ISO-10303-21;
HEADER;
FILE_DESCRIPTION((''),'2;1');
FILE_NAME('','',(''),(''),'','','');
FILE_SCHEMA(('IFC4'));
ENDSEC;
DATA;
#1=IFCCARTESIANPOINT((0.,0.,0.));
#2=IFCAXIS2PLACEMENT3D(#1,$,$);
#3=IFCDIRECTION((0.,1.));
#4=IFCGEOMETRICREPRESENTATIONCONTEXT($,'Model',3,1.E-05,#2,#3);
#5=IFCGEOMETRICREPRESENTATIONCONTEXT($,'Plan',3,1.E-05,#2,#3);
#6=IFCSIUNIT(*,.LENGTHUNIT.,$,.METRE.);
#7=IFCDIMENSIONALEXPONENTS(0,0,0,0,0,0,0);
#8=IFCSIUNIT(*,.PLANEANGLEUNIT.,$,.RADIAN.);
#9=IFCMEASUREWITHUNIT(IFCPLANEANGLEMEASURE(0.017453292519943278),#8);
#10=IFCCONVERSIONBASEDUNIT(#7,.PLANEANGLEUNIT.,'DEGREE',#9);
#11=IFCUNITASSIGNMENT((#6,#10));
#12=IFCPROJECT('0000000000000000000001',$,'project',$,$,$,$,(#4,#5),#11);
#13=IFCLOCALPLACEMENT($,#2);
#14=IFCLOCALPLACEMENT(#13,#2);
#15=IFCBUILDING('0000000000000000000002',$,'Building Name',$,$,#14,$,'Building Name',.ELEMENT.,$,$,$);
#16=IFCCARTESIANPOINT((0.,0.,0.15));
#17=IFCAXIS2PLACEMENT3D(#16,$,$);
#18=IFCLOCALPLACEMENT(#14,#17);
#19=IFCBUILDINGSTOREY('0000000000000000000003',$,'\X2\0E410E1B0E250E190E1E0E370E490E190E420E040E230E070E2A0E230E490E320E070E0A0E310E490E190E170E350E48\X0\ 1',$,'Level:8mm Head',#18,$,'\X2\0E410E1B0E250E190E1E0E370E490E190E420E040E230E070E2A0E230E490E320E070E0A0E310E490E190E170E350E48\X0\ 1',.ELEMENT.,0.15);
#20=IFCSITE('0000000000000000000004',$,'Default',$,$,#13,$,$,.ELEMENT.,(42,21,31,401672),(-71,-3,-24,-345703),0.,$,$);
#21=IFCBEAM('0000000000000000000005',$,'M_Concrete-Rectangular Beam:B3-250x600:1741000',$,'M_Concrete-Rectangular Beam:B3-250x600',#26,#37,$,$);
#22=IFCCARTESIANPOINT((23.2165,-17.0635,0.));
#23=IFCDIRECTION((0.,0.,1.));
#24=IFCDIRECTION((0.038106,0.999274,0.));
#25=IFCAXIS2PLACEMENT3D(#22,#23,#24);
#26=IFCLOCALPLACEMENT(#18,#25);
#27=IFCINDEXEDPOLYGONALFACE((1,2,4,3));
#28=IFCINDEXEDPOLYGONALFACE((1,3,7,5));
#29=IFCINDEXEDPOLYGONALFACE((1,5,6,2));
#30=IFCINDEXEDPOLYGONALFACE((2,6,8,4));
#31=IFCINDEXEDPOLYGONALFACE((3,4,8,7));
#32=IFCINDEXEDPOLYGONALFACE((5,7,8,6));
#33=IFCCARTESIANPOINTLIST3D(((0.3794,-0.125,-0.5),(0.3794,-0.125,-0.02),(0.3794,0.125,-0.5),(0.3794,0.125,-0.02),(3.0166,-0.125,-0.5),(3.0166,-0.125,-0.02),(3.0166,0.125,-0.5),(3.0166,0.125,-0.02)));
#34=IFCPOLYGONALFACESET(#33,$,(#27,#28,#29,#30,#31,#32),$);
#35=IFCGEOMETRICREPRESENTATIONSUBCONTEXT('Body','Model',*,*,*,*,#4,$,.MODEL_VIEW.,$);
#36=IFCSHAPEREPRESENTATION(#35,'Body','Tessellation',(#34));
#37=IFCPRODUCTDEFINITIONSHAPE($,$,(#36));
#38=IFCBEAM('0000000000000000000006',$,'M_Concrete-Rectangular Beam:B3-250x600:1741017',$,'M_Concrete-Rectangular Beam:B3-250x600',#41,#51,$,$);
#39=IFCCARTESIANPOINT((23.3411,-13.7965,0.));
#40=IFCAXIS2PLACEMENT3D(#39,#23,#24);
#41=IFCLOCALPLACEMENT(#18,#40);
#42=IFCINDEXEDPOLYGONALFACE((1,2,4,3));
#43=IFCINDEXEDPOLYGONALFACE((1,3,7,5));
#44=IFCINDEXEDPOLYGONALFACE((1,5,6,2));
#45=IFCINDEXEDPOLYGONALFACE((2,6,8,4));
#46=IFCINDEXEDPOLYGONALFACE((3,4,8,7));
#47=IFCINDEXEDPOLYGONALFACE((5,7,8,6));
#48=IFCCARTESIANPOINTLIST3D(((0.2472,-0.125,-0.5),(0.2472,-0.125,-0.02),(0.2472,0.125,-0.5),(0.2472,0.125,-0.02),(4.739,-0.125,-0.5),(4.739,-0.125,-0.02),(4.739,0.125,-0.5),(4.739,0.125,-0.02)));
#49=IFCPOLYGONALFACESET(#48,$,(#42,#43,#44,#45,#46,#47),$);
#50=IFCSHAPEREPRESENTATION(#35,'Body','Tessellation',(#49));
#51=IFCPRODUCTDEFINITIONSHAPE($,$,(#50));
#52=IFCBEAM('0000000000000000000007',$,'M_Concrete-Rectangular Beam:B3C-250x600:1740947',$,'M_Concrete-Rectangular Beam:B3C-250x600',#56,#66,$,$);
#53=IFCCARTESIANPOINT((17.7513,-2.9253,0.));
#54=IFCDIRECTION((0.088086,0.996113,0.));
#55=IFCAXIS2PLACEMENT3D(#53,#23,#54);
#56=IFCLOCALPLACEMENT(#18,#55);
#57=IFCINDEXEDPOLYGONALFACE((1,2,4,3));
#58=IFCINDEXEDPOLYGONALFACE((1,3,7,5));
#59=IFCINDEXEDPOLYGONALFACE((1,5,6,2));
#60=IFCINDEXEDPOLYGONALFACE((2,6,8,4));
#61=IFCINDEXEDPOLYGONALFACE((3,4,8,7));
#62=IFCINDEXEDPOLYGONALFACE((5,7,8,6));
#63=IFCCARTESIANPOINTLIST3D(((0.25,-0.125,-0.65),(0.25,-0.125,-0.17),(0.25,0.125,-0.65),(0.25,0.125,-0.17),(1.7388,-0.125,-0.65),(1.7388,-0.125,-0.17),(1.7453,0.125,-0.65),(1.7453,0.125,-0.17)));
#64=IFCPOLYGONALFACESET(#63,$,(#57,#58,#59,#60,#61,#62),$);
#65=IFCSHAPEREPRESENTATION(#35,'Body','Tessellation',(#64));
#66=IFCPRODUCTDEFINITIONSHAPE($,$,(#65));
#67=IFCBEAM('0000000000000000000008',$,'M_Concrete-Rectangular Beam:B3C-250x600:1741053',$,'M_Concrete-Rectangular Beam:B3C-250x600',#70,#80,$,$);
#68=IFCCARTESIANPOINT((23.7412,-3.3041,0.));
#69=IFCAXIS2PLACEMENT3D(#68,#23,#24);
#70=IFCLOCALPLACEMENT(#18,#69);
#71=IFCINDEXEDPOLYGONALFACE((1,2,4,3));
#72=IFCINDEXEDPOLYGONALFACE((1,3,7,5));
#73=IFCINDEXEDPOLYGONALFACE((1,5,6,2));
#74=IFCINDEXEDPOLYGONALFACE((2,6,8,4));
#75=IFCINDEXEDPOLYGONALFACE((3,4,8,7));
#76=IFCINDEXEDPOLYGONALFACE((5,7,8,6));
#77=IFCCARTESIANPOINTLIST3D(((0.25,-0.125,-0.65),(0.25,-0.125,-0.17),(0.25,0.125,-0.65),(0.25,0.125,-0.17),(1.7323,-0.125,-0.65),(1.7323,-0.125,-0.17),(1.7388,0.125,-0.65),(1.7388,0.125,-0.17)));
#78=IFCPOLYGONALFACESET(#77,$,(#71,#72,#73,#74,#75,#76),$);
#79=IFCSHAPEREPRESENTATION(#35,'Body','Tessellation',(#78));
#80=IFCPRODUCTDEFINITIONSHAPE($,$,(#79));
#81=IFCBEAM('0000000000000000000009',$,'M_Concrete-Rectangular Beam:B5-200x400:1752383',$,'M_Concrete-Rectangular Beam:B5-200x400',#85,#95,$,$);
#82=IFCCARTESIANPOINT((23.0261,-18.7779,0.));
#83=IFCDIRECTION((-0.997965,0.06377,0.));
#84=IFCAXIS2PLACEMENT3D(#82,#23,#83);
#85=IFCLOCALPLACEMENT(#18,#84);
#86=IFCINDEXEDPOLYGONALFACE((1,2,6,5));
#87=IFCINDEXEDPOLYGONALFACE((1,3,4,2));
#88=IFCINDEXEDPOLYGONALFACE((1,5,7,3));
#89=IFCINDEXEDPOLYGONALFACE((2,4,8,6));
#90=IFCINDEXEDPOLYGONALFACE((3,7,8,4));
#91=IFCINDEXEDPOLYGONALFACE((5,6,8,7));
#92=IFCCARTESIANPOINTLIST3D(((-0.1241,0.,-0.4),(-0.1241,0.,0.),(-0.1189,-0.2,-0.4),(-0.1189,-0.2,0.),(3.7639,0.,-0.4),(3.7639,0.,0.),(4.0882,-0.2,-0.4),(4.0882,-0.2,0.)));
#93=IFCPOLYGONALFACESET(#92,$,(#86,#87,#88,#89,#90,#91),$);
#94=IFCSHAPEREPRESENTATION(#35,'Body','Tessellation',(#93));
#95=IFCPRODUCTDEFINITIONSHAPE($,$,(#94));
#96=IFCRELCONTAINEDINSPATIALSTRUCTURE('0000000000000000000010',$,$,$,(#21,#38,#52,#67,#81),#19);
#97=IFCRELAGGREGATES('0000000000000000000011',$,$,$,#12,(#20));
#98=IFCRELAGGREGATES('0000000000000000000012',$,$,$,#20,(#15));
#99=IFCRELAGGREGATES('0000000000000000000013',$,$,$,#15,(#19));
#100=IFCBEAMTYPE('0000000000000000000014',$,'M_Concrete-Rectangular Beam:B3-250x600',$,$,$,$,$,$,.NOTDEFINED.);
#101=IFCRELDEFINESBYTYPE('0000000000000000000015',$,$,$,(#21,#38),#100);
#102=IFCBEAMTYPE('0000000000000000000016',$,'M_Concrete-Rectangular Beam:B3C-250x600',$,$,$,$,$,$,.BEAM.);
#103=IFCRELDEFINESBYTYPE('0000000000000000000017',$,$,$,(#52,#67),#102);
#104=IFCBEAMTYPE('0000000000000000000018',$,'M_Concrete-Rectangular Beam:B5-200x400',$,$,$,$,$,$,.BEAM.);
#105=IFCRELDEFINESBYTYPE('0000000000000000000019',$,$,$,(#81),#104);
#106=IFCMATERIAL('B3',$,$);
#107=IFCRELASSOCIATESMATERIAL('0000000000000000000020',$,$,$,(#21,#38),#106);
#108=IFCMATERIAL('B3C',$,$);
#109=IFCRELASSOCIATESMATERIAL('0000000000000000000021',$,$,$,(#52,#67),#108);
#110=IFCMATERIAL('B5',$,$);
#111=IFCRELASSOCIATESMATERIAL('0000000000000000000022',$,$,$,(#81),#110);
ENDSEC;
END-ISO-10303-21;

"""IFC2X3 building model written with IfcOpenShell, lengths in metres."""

from ifc_helpers import new_model, entity, si_unit, converted_unit, direction, frame, frame_2d, origin, place, context, subcontext, project, spatial, rectangle, extrude, clip, halfspace, material, type_object, element, save


model = new_model("IFC2X3")

# Units and contexts
model_context = context("Model", 3, precision=1e-05, world=origin(), true_north=direction((0.0, 1.0)))
plan_context = context("Plan", 3, precision=1e-05, world=origin(), true_north=direction((0.0, 1.0)))
body_context = subcontext(model_context, "Body", "Model", "MODEL_VIEW")
ifc_project = project(units=[si_unit("LENGTHUNIT", "METRE"), converted_unit("PLANEANGLEUNIT", "DEGREE", entity("IfcPlaneAngleMeasure", 0.017453292519943278), si_unit("PLANEANGLEUNIT", "RADIAN"), dimensions=[0, 0, 0, 0, 0, 0, 0])], contexts=[model_context, plan_context])

# Site, building, storey
site_placement = place(None, origin())
site = spatial("IfcSite", under=ifc_project, at=site_placement, Name="Default", CompositionType="ELEMENT", RefLatitude=(42, 21, 31, 401672), RefLongitude=(-71, -3, -24, -345703), RefElevation=0.0)
building_placement = place(site_placement, origin())
building = spatial("IfcBuilding", under=site, at=building_placement, Name="Building Name", LongName="Building Name", CompositionType="ELEMENT")
storey_placement = place(building_placement, frame((0.0, 0.0, 0.15)))
storey = spatial("IfcBuildingStorey", under=building, at=storey_placement, Name="แปลนพื้นโครงสร้างชั้นที่ 1", ObjectType="Level:8mm Head", LongName="แปลนพื้นโครงสร้างชั้นที่ 1", CompositionType="ELEMENT", Elevation=0.15)

# Beams
ifc_material_1 = material(Name="B3")
beam_type_1 = type_object("IfcBeamType", Name="M_Concrete-Rectangular Beam:B3-250x600", PredefinedType="NOTDEFINED")
beam_1_placement = place(storey_placement, frame((23.2165, -17.0635, 0.0), z_axis=(0.0, 0.0, 1.0), x_axis=(0.038106, 0.999274, 0.0)))
element("IfcBeam", 1, at=beam_1_placement, inside=storey, type_object=beam_type_1, material=ifc_material_1, Name="M_Concrete-Rectangular Beam:B3-250x600:1741000", ObjectType="M_Concrete-Rectangular Beam:B3-250x600", context=body_context, shape_type="SweptSolid", body=[
    extrude(rectangle(XDim=0.48, YDim=0.25, at=frame_2d((0.0, 0.0), x_axis=(1.0, 0.0))), frame((0.3794, 0.0, -0.26), z_axis=(1.0, 0.0, 0.0), x_axis=(0.0, 0.0, -1.0)), (0.0, 0.0, 1.0), 2.6372),
])
beam_2_placement = place(storey_placement, frame((23.3411, -13.7965, 0.0), z_axis=(0.0, 0.0, 1.0), x_axis=(0.038106, 0.999274, 0.0)))
element("IfcBeam", 2, at=beam_2_placement, inside=storey, type_object=beam_type_1, material=ifc_material_1, Name="M_Concrete-Rectangular Beam:B3-250x600:1741017", ObjectType="M_Concrete-Rectangular Beam:B3-250x600", context=body_context, shape_type="SweptSolid", body=[
    extrude(rectangle(XDim=0.48, YDim=0.25, at=frame_2d((0.0, 0.0), x_axis=(1.0, 0.0))), frame((0.2472, 0.0, -0.26), z_axis=(1.0, 0.0, 0.0), x_axis=(0.0, 0.0, -1.0)), (0.0, 0.0, 1.0), 4.4918),
])
ifc_material_2 = material(Name="B3C")
beam_type_2 = type_object("IfcBeamType", Name="M_Concrete-Rectangular Beam:B3C-250x600", PredefinedType="BEAM")
beam_3_placement = place(storey_placement, frame((17.7513, -2.9253, 0.0), z_axis=(0.0, 0.0, 1.0), x_axis=(0.088086, 0.996113, 0.0)))
element("IfcBeam", 3, at=beam_3_placement, inside=storey, type_object=beam_type_2, material=ifc_material_2, Name="M_Concrete-Rectangular Beam:B3C-250x600:1740947", ObjectType="M_Concrete-Rectangular Beam:B3C-250x600", context=body_context, shape_type="Clipping", body=[
    clip(extrude(rectangle(XDim=0.48, YDim=0.25, at=frame_2d((0.0, 0.0), x_axis=(1.0, 0.0))), frame((0.25, 0.0, -0.41), z_axis=(1.0, 0.0, 0.0), x_axis=(0.0, 0.0, -1.0)), (0.0, 0.0, 1.0), 1.4953), halfspace(frame((1.7459, 0.149, -0.05), z_axis=(0.999667, -0.02582, 0.0), x_axis=(-0.02582, -0.999667, 0.0)), False)),
])
beam_4_placement = place(storey_placement, frame((23.7412, -3.3041, 0.0), z_axis=(0.0, 0.0, 1.0), x_axis=(0.038106, 0.999274, 0.0)))
element("IfcBeam", 4, at=beam_4_placement, inside=storey, type_object=beam_type_2, material=ifc_material_2, Name="M_Concrete-Rectangular Beam:B3C-250x600:1741053", ObjectType="M_Concrete-Rectangular Beam:B3C-250x600", context=body_context, shape_type="Clipping", body=[
    clip(extrude(rectangle(XDim=0.48, YDim=0.25, at=frame_2d((0.0, 0.0), x_axis=(1.0, 0.0))), frame((0.25, 0.0, -0.41), z_axis=(1.0, 0.0, 0.0), x_axis=(0.0, 0.0, -1.0)), (0.0, 0.0, 1.0), 1.4888), halfspace(frame((1.7395, 0.149, -0.05), z_axis=(0.999658, -0.026133, 0.0), x_axis=(-0.026133, -0.999658, 0.0)), False)),
])
ifc_material_3 = material(Name="B5")
beam_type_3 = type_object("IfcBeamType", Name="M_Concrete-Rectangular Beam:B5-200x400", PredefinedType="BEAM")
beam_5_placement = place(storey_placement, frame((23.0261, -18.7779, 0.0), z_axis=(0.0, 0.0, 1.0), x_axis=(-0.997965, 0.06377, 0.0)))
element("IfcBeam", 5, at=beam_5_placement, inside=storey, type_object=beam_type_3, material=ifc_material_3, Name="M_Concrete-Rectangular Beam:B5-200x400:1752383", ObjectType="M_Concrete-Rectangular Beam:B5-200x400", context=body_context, shape_type="Clipping", body=[
    clip(clip(extrude(rectangle(XDim=0.4, YDim=0.2, at=frame_2d((0.0, 0.0), x_axis=(1.0, 0.0))), frame((-0.1241, -0.1, -0.2), z_axis=(1.0, 0.0, 0.0), x_axis=(0.0, 0.0, -1.0)), (0.0, 0.0, 1.0), 4.2123), halfspace(frame((6.4029, -1.6278, 0.0), z_axis=(0.525004, 0.8511, 0.0), x_axis=(-0.8511, 0.525004, 0.0)), False)), halfspace(frame((-0.1189, -0.2, 0.0), z_axis=(-0.999667, -0.025823, 0.0), x_axis=(0.025823, -0.999667, 0.0)), False)),
])

save(model, "model.ifc")
